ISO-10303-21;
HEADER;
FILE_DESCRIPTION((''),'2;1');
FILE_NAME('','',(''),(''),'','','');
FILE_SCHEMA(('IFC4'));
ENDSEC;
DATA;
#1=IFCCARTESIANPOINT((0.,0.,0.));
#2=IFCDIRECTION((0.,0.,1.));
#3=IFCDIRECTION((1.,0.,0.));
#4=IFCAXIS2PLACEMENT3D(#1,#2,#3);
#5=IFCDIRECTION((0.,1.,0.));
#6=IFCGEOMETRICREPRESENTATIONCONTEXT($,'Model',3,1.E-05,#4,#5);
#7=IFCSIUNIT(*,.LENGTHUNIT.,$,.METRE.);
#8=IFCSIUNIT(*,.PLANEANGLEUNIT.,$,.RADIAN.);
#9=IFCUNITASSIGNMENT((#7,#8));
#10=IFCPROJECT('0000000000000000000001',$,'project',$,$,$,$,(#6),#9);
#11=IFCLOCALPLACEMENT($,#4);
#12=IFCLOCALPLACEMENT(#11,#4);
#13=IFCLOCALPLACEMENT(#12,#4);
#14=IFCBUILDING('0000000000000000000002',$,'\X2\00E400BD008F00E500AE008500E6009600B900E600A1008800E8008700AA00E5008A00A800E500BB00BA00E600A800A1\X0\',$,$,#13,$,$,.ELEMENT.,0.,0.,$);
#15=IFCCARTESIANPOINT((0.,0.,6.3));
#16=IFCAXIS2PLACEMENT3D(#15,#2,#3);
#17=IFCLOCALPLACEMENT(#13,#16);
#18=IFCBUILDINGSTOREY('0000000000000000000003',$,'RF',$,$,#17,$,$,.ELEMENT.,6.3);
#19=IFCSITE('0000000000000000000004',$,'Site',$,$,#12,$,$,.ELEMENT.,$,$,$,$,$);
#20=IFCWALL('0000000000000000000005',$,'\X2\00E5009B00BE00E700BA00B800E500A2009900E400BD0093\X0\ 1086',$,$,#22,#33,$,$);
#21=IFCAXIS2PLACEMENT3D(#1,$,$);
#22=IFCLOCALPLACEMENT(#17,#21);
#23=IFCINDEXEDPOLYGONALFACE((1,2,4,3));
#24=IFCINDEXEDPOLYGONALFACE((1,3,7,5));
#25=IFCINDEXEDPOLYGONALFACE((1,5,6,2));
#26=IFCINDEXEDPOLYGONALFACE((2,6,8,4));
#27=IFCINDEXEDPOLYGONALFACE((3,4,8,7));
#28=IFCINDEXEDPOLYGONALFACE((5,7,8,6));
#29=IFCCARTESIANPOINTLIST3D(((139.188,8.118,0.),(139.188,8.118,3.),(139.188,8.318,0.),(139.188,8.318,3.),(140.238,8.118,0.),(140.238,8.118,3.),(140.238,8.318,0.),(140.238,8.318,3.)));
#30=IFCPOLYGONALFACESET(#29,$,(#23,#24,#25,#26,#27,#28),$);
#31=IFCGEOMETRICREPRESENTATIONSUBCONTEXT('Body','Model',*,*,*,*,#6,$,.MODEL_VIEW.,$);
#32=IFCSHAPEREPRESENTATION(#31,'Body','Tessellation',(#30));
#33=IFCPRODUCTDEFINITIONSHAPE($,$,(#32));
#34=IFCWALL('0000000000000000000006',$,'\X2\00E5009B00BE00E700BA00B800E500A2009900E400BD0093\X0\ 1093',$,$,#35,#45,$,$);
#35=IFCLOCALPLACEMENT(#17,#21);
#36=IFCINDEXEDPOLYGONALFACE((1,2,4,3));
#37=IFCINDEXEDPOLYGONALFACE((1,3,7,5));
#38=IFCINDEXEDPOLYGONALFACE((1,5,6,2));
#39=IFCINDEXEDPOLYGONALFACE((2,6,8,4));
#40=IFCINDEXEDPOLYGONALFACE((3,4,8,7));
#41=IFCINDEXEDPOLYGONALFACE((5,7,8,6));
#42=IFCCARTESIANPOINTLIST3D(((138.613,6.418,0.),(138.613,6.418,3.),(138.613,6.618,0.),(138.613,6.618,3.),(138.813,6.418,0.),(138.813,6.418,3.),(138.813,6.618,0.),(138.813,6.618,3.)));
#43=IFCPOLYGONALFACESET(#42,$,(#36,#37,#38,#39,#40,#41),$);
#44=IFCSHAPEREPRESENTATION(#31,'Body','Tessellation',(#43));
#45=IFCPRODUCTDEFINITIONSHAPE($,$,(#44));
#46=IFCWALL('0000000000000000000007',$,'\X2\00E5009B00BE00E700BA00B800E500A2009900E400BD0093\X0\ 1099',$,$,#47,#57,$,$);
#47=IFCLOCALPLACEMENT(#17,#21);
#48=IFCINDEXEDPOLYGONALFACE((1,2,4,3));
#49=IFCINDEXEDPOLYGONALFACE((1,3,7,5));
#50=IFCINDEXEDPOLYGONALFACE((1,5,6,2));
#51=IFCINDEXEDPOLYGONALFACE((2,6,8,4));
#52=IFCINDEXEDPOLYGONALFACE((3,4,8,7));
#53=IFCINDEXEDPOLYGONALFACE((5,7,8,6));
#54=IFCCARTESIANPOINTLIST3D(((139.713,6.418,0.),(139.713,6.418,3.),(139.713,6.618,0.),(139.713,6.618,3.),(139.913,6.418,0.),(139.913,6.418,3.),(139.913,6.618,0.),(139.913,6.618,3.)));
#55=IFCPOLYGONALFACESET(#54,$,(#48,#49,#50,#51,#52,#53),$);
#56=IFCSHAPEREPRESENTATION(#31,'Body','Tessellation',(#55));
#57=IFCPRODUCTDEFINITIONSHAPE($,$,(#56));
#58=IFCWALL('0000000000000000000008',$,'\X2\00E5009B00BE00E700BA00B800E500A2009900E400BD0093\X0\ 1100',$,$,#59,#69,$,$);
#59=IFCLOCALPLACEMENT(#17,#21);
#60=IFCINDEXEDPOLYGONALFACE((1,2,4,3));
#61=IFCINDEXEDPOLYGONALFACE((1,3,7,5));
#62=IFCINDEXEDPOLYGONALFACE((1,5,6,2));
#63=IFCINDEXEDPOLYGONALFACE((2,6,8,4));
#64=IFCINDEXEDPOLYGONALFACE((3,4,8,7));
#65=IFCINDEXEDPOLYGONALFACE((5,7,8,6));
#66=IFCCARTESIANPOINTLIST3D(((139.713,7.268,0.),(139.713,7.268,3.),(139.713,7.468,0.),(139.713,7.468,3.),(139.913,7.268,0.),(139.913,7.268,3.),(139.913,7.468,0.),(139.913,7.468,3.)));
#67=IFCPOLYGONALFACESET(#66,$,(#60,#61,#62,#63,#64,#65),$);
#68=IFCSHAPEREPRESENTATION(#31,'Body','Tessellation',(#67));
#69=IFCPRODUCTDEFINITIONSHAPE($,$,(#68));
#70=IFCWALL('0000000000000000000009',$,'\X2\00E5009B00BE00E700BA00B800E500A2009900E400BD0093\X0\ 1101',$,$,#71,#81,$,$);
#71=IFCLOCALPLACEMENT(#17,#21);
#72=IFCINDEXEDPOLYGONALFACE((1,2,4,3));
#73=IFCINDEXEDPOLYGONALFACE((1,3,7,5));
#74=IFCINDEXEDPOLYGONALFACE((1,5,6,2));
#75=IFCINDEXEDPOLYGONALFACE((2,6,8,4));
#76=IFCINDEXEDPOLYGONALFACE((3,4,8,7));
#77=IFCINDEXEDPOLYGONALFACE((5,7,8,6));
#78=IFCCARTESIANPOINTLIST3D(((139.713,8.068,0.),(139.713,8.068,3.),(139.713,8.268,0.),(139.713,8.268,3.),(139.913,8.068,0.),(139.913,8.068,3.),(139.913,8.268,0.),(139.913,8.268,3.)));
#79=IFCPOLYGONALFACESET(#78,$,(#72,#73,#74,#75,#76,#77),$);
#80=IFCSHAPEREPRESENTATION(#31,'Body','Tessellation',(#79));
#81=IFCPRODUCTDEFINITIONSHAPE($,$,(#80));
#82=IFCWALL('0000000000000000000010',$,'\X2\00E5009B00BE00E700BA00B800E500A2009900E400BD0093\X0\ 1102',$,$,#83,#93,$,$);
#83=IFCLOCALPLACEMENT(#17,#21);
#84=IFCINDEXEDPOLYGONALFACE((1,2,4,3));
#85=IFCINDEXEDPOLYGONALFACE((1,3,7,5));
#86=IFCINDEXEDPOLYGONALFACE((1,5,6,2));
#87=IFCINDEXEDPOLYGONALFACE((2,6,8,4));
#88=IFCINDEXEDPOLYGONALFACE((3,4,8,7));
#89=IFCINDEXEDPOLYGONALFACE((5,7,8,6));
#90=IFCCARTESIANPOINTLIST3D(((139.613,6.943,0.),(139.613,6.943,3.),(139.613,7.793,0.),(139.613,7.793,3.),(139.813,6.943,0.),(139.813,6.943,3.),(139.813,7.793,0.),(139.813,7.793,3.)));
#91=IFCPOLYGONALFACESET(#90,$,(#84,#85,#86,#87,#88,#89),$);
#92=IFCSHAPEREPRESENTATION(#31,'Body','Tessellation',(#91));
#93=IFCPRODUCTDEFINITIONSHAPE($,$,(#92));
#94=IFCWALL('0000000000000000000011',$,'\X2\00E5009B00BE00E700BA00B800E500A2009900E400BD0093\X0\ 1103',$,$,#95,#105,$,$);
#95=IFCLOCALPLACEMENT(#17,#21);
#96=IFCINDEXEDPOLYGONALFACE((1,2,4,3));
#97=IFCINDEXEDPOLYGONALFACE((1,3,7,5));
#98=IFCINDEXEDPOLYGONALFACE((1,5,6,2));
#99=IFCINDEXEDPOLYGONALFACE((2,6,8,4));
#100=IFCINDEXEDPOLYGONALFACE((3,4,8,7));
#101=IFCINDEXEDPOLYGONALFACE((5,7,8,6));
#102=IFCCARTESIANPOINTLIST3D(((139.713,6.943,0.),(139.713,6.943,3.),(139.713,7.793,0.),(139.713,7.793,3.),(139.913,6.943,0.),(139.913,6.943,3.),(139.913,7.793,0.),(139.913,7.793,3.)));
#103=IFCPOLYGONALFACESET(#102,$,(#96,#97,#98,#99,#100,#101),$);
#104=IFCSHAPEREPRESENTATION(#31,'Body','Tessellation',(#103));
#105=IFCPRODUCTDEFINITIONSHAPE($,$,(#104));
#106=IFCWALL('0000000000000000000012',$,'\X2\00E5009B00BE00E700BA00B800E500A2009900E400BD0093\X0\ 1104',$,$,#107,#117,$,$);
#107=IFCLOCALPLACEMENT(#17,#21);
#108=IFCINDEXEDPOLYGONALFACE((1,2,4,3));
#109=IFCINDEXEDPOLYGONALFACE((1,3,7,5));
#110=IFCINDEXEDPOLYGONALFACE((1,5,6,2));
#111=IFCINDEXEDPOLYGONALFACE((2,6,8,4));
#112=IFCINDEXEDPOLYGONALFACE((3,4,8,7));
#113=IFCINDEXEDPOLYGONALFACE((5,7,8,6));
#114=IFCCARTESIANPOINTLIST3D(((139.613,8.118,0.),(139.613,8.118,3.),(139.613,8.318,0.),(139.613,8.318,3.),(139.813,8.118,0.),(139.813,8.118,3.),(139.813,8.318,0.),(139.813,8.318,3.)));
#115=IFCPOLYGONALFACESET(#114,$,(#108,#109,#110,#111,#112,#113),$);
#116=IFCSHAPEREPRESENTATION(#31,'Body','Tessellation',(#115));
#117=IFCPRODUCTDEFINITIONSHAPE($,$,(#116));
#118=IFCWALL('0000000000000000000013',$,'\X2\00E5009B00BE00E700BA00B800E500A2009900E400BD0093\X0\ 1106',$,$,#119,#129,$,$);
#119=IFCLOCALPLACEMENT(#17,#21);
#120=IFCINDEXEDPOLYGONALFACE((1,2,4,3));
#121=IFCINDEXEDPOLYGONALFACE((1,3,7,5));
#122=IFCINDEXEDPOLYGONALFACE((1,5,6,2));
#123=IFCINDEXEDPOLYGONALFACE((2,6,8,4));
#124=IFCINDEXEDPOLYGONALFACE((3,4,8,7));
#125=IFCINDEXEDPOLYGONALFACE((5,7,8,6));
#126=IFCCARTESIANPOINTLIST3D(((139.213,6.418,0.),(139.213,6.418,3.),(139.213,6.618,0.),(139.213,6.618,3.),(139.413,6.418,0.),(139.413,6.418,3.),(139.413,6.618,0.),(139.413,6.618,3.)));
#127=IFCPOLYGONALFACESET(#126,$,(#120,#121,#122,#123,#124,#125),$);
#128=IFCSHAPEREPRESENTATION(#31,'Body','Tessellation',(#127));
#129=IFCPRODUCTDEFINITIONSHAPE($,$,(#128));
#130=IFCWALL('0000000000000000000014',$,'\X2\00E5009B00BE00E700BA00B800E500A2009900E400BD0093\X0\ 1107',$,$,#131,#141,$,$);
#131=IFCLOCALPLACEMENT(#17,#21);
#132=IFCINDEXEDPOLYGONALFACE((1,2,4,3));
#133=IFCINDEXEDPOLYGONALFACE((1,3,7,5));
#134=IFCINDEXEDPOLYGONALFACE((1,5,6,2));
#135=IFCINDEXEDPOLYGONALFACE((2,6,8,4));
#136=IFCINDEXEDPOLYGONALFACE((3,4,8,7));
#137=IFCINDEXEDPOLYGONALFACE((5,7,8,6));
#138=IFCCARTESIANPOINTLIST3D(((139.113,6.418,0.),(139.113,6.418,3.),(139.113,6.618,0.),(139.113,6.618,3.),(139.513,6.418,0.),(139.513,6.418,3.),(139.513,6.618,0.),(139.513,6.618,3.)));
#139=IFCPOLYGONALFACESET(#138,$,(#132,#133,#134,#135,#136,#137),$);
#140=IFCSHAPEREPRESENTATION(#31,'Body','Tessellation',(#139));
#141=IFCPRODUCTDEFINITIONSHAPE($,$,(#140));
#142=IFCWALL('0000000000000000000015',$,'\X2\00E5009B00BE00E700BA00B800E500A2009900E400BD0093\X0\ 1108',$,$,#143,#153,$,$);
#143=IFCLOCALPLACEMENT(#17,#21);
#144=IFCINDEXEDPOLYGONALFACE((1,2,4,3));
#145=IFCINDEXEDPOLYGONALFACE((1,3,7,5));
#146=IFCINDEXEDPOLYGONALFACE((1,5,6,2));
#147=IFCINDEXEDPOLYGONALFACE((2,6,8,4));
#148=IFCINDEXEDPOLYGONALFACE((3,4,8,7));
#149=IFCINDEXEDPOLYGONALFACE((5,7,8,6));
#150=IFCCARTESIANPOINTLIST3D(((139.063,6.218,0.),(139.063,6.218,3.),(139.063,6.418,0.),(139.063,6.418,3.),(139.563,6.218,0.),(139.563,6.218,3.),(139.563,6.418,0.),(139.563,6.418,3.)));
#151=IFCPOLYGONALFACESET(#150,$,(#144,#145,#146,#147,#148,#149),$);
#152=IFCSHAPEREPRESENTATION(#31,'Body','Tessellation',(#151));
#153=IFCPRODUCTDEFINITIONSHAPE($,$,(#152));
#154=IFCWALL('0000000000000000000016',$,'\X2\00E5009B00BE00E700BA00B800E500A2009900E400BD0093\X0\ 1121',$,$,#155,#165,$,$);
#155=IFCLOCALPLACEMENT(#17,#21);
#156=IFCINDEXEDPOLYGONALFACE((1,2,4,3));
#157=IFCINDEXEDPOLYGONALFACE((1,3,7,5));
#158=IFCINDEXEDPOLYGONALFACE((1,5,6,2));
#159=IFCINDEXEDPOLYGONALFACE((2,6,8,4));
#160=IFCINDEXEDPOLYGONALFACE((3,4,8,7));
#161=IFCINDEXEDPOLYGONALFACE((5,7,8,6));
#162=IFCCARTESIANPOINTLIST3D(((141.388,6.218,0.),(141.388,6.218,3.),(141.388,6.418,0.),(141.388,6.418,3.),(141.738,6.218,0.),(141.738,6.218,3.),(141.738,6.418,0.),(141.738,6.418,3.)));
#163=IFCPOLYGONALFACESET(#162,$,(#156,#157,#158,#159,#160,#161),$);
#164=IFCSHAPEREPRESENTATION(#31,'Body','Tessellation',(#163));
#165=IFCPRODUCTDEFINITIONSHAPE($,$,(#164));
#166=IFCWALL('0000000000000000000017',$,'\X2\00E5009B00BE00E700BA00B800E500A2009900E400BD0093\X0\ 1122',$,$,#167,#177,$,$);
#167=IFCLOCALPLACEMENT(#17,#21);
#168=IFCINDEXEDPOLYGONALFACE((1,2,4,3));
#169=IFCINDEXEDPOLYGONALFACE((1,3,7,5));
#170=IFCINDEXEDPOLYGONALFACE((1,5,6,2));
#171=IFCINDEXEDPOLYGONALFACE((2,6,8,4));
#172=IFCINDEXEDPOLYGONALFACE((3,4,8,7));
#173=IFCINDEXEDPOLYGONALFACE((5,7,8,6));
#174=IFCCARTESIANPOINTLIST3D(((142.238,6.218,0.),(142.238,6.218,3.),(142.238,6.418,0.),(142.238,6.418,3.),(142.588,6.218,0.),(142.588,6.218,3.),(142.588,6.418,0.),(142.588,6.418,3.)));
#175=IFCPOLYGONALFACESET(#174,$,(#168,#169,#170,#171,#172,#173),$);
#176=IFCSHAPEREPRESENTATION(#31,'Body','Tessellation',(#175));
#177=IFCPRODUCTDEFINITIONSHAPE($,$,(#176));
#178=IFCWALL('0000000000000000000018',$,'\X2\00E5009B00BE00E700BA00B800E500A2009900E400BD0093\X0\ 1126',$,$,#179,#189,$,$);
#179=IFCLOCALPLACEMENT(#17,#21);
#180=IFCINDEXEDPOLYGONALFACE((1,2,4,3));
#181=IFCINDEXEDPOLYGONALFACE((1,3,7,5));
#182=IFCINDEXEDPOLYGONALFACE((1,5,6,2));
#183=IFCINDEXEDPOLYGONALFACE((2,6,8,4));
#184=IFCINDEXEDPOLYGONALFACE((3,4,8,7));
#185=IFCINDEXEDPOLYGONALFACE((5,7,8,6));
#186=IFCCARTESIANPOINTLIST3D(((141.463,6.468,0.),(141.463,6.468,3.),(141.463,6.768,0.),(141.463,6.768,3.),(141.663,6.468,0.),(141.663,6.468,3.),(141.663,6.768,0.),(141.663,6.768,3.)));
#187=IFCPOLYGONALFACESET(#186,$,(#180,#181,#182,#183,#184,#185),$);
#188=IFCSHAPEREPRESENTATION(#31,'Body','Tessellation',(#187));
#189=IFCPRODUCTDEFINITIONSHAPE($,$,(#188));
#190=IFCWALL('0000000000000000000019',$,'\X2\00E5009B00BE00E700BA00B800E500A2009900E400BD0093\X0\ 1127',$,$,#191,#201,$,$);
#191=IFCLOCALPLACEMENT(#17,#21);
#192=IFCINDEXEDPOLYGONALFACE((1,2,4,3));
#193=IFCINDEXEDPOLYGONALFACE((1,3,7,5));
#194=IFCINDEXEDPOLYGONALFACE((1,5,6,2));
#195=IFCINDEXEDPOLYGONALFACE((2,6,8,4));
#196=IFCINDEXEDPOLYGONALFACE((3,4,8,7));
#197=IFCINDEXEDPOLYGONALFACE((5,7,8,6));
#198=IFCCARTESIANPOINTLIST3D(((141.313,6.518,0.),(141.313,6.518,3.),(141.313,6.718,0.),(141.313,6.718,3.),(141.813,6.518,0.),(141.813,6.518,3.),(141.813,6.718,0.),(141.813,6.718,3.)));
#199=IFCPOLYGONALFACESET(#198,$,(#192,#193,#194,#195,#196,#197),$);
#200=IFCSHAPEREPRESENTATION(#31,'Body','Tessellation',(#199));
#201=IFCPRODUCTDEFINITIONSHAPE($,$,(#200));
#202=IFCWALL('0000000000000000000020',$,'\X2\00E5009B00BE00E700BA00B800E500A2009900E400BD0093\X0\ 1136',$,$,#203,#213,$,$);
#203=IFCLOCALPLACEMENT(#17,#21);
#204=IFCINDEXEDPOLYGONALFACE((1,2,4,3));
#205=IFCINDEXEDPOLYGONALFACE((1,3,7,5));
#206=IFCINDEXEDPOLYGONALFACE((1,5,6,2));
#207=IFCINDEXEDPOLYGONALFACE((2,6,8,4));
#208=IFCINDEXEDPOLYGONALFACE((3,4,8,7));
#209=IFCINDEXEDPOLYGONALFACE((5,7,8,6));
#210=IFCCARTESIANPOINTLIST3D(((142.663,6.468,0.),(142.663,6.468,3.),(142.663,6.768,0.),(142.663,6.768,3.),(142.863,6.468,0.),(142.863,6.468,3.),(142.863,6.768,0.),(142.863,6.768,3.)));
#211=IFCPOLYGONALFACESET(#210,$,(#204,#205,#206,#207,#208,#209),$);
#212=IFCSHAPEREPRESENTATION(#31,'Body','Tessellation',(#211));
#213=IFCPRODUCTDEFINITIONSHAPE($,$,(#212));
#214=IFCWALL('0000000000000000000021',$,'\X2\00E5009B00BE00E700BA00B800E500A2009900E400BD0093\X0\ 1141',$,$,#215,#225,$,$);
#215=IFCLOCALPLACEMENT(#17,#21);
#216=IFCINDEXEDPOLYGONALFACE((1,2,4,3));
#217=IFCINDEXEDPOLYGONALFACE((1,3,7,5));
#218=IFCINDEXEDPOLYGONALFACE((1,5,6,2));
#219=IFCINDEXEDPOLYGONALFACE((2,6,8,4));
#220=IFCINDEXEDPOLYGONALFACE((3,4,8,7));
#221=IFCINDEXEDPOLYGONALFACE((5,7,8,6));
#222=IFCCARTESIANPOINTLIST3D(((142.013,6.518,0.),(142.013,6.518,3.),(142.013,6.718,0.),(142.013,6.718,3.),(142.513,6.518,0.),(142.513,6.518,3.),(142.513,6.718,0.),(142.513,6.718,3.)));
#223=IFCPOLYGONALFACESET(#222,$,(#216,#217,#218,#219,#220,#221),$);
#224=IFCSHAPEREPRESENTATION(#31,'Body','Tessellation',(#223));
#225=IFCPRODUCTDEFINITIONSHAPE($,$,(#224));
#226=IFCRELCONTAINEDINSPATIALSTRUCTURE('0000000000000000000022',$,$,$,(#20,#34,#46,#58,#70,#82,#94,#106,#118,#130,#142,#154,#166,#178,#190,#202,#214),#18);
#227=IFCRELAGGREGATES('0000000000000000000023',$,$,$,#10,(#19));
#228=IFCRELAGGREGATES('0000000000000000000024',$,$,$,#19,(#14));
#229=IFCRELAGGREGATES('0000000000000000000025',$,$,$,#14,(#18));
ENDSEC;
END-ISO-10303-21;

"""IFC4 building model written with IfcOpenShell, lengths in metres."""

from ifc_helpers import new_model, si_unit, direction, frame, frame_2d, origin_with_axes, place, context, subcontext, project, spatial, rectangle, extrude, element, save


model = new_model("IFC4")

# Units and contexts
model_context = context("Model", 3, precision=1e-05, world=origin_with_axes(), true_north=direction((0.0, 1.0, 0.0)))
body_context = subcontext(model_context, "Body", "Model", "MODEL_VIEW")
ifc_project = project(units=[si_unit("LENGTHUNIT", "METRE"), si_unit("PLANEANGLEUNIT", "RADIAN")], contexts=[model_context])

# Site, building, storey
placement = place(None, origin_with_axes())
site_placement = place(placement, origin_with_axes())
site = spatial("IfcSite", under=ifc_project, at=site_placement, Name="Site", CompositionType="ELEMENT")
building_placement = place(site_placement, origin_with_axes())
building = spatial("IfcBuilding", under=site, at=building_placement, Name="ä½\u008få®\u0085æ\u0096¹æ¡\u0088è\u0087ªå\u008a¨å»ºæ¨¡", CompositionType="ELEMENT", ElevationOfRefHeight=0.0, ElevationOfTerrain=0.0)
storey_placement = place(building_placement, frame((0.0, 0.0, 6.3), z_axis=(0.0, 0.0, 1.0), x_axis=(1.0, 0.0, 0.0)))
storey = spatial("IfcBuildingStorey", under=building, at=storey_placement, Name="RF", CompositionType="ELEMENT", Elevation=6.3)

# Walls
wall_1_placement = place(storey_placement, frame((139.713, 8.218, 0.0), z_axis=(0.0, 0.0, 1.0), x_axis=(-1.0, 0.0, 0.0)))
element("IfcWall", 1, at=wall_1_placement, inside=storey, Name="å\u009b¾çº¸å¢\u0099ä½\u0093 1086", context=body_context, shape_type="SweptSolid", body=[
    extrude(rectangle(XDim=1.05, YDim=0.2, at=frame_2d((0.0, 0.0), x_axis=(1.0, 0.0, 0.0))), frame((0.0, 0.0, 0.0), z_axis=(0.0, 0.0, 1.0)), (0.0, 0.0, 1.0), 3.0),
])
for number, where, z_axis, x_axis, name in (
    (2, (138.713, 6.518, 0.0), (0.0, 0.0, 1.0), (0.0, -1.0, 0.0), "å\u009b¾çº¸å¢\u0099ä½\u0093 1093"),
    (3, (139.813, 6.518, 0.0), (0.0, 0.0, 1.0), (0.0, -1.0, 0.0), "å\u009b¾çº¸å¢\u0099ä½\u0093 1099"),
    (4, (139.813, 7.368, 0.0), (0.0, 0.0, 1.0), (-1.0, 0.0, 0.0), "å\u009b¾çº¸å¢\u0099ä½\u0093 1100"),
    (5, (139.813, 8.168, 0.0), (0.0, 0.0, 1.0), (-1.0, 0.0, 0.0), "å\u009b¾çº¸å¢\u0099ä½\u0093 1101"),
):
    element("IfcWall", number, at=place(storey_placement, frame(where, z_axis=z_axis, x_axis=x_axis)), inside=storey, Name=name, context=body_context, shape_type="SweptSolid", body=[
        extrude(rectangle(XDim=0.2, YDim=0.2, at=frame_2d((0.0, 0.0), x_axis=(1.0, 0.0, 0.0))), frame((0.0, 0.0, 0.0), z_axis=(0.0, 0.0, 1.0)), (0.0, 0.0, 1.0), 3.0),
    ])
for number, where, z_axis, x_axis, name in (
    (6, (139.713, 7.368, 0.0), (0.0, 0.0, 1.0), (0.0, -1.0, 0.0), "å\u009b¾çº¸å¢\u0099ä½\u0093 1102"),
    (7, (139.813, 7.368, 0.0), (0.0, 0.0, 1.0), (0.0, -1.0, 0.0), "å\u009b¾çº¸å¢\u0099ä½\u0093 1103"),
):
    element("IfcWall", number, at=place(storey_placement, frame(where, z_axis=z_axis, x_axis=x_axis)), inside=storey, Name=name, context=body_context, shape_type="SweptSolid", body=[
        extrude(rectangle(XDim=0.85, YDim=0.2, at=frame_2d((0.0, 0.0), x_axis=(1.0, 0.0, 0.0))), frame((0.0, 0.0, 0.0), z_axis=(0.0, 0.0, 1.0)), (0.0, 0.0, 1.0), 3.0),
    ])
for number, where, z_axis, x_axis, name in (
    (8, (139.713, 8.218, 0.0), (0.0, 0.0, 1.0), (0.0, -1.0, 0.0), "å\u009b¾çº¸å¢\u0099ä½\u0093 1104"),
    (9, (139.313, 6.518, 0.0), (0.0, 0.0, 1.0), (0.0, -1.0, 0.0), "å\u009b¾çº¸å¢\u0099ä½\u0093 1106"),
):
    element("IfcWall", number, at=place(storey_placement, frame(where, z_axis=z_axis, x_axis=x_axis)), inside=storey, Name=name, context=body_context, shape_type="SweptSolid", body=[
        extrude(rectangle(XDim=0.2, YDim=0.2, at=frame_2d((0.0, 0.0), x_axis=(1.0, 0.0, 0.0))), frame((0.0, 0.0, 0.0), z_axis=(0.0, 0.0, 1.0)), (0.0, 0.0, 1.0), 3.0),
    ])
wall_2_placement = place(storey_placement, frame((139.313, 6.518, 0.0), z_axis=(0.0, 0.0, 1.0), x_axis=(1.0, 0.0, 0.0)))
element("IfcWall", 10, at=wall_2_placement, inside=storey, Name="å\u009b¾çº¸å¢\u0099ä½\u0093 1107", context=body_context, shape_type="SweptSolid", body=[
    extrude(rectangle(XDim=0.4, YDim=0.2, at=frame_2d((0.0, 0.0), x_axis=(1.0, 0.0, 0.0))), frame((0.0, 0.0, 0.0), z_axis=(0.0, 0.0, 1.0)), (0.0, 0.0, 1.0), 3.0),
])
wall_3_placement = place(storey_placement, frame((139.313, 6.318, 0.0), z_axis=(0.0, 0.0, 1.0), x_axis=(1.0, 0.0, 0.0)))
element("IfcWall", 11, at=wall_3_placement, inside=storey, Name="å\u009b¾çº¸å¢\u0099ä½\u0093 1108", context=body_context, shape_type="SweptSolid", body=[
    extrude(rectangle(XDim=0.5, YDim=0.2, at=frame_2d((0.0, 0.0), x_axis=(1.0, 0.0, 0.0))), frame((0.0, 0.0, 0.0), z_axis=(0.0, 0.0, 1.0)), (0.0, 0.0, 1.0), 3.0),
])
for number, where, z_axis, x_axis, name in (
    (12, (141.563, 6.318, 0.0), (0.0, 0.0, 1.0), (1.0, 0.0, 0.0), "å\u009b¾çº¸å¢\u0099ä½\u0093 1121"),
    (13, (142.413, 6.318, 0.0), (0.0, 0.0, 1.0), (1.0, 0.0, 0.0), "å\u009b¾çº¸å¢\u0099ä½\u0093 1122"),
):
    element("IfcWall", number, at=place(storey_placement, frame(where, z_axis=z_axis, x_axis=x_axis)), inside=storey, Name=name, context=body_context, shape_type="SweptSolid", body=[
        extrude(rectangle(XDim=0.35, YDim=0.2, at=frame_2d((0.0, 0.0), x_axis=(1.0, 0.0, 0.0))), frame((0.0, 0.0, 0.0), z_axis=(0.0, 0.0, 1.0)), (0.0, 0.0, 1.0), 3.0),
    ])
wall_4_placement = place(storey_placement, frame((141.563, 6.618, 0.0), z_axis=(0.0, 0.0, 1.0), x_axis=(0.0, -1.0, 0.0)))
element("IfcWall", 14, at=wall_4_placement, inside=storey, Name="å\u009b¾çº¸å¢\u0099ä½\u0093 1126", context=body_context, shape_type="SweptSolid", body=[
    extrude(rectangle(XDim=0.3, YDim=0.2, at=frame_2d((0.0, 0.0), x_axis=(1.0, 0.0, 0.0))), frame((0.0, 0.0, 0.0), z_axis=(0.0, 0.0, 1.0)), (0.0, 0.0, 1.0), 3.0),
])
wall_5_placement = place(storey_placement, frame((141.563, 6.618, 0.0), z_axis=(0.0, 0.0, 1.0), x_axis=(1.0, 0.0, 0.0)))
element("IfcWall", 15, at=wall_5_placement, inside=storey, Name="å\u009b¾çº¸å¢\u0099ä½\u0093 1127", context=body_context, shape_type="SweptSolid", body=[
    extrude(rectangle(XDim=0.5, YDim=0.2, at=frame_2d((0.0, 0.0), x_axis=(1.0, 0.0, 0.0))), frame((0.0, 0.0, 0.0), z_axis=(0.0, 0.0, 1.0)), (0.0, 0.0, 1.0), 3.0),
])
wall_6_placement = place(storey_placement, frame((142.763, 6.618, 0.0), z_axis=(0.0, 0.0, 1.0), x_axis=(0.0, -1.0, 0.0)))
element("IfcWall", 16, at=wall_6_placement, inside=storey, Name="å\u009b¾çº¸å¢\u0099ä½\u0093 1136", context=body_context, shape_type="SweptSolid", body=[
    extrude(rectangle(XDim=0.3, YDim=0.2, at=frame_2d((0.0, 0.0), x_axis=(1.0, 0.0, 0.0))), frame((0.0, 0.0, 0.0), z_axis=(0.0, 0.0, 1.0)), (0.0, 0.0, 1.0), 3.0),
])
for number, where, z_axis, x_axis, name in (
    (17, (142.263, 6.618, 0.0), (0.0, 0.0, 1.0), (1.0, 0.0, 0.0), "å\u009b¾çº¸å¢\u0099ä½\u0093 1141"),
):
    element("IfcWall", number, at=place(storey_placement, frame(where, z_axis=z_axis, x_axis=x_axis)), inside=storey, Name=name, context=body_context, shape_type="SweptSolid", body=[
        extrude(rectangle(XDim=0.5, YDim=0.2, at=frame_2d((0.0, 0.0), x_axis=(1.0, 0.0, 0.0))), frame((0.0, 0.0, 0.0), z_axis=(0.0, 0.0, 1.0)), (0.0, 0.0, 1.0), 3.0),
    ])

save(model, "model.ifc")
